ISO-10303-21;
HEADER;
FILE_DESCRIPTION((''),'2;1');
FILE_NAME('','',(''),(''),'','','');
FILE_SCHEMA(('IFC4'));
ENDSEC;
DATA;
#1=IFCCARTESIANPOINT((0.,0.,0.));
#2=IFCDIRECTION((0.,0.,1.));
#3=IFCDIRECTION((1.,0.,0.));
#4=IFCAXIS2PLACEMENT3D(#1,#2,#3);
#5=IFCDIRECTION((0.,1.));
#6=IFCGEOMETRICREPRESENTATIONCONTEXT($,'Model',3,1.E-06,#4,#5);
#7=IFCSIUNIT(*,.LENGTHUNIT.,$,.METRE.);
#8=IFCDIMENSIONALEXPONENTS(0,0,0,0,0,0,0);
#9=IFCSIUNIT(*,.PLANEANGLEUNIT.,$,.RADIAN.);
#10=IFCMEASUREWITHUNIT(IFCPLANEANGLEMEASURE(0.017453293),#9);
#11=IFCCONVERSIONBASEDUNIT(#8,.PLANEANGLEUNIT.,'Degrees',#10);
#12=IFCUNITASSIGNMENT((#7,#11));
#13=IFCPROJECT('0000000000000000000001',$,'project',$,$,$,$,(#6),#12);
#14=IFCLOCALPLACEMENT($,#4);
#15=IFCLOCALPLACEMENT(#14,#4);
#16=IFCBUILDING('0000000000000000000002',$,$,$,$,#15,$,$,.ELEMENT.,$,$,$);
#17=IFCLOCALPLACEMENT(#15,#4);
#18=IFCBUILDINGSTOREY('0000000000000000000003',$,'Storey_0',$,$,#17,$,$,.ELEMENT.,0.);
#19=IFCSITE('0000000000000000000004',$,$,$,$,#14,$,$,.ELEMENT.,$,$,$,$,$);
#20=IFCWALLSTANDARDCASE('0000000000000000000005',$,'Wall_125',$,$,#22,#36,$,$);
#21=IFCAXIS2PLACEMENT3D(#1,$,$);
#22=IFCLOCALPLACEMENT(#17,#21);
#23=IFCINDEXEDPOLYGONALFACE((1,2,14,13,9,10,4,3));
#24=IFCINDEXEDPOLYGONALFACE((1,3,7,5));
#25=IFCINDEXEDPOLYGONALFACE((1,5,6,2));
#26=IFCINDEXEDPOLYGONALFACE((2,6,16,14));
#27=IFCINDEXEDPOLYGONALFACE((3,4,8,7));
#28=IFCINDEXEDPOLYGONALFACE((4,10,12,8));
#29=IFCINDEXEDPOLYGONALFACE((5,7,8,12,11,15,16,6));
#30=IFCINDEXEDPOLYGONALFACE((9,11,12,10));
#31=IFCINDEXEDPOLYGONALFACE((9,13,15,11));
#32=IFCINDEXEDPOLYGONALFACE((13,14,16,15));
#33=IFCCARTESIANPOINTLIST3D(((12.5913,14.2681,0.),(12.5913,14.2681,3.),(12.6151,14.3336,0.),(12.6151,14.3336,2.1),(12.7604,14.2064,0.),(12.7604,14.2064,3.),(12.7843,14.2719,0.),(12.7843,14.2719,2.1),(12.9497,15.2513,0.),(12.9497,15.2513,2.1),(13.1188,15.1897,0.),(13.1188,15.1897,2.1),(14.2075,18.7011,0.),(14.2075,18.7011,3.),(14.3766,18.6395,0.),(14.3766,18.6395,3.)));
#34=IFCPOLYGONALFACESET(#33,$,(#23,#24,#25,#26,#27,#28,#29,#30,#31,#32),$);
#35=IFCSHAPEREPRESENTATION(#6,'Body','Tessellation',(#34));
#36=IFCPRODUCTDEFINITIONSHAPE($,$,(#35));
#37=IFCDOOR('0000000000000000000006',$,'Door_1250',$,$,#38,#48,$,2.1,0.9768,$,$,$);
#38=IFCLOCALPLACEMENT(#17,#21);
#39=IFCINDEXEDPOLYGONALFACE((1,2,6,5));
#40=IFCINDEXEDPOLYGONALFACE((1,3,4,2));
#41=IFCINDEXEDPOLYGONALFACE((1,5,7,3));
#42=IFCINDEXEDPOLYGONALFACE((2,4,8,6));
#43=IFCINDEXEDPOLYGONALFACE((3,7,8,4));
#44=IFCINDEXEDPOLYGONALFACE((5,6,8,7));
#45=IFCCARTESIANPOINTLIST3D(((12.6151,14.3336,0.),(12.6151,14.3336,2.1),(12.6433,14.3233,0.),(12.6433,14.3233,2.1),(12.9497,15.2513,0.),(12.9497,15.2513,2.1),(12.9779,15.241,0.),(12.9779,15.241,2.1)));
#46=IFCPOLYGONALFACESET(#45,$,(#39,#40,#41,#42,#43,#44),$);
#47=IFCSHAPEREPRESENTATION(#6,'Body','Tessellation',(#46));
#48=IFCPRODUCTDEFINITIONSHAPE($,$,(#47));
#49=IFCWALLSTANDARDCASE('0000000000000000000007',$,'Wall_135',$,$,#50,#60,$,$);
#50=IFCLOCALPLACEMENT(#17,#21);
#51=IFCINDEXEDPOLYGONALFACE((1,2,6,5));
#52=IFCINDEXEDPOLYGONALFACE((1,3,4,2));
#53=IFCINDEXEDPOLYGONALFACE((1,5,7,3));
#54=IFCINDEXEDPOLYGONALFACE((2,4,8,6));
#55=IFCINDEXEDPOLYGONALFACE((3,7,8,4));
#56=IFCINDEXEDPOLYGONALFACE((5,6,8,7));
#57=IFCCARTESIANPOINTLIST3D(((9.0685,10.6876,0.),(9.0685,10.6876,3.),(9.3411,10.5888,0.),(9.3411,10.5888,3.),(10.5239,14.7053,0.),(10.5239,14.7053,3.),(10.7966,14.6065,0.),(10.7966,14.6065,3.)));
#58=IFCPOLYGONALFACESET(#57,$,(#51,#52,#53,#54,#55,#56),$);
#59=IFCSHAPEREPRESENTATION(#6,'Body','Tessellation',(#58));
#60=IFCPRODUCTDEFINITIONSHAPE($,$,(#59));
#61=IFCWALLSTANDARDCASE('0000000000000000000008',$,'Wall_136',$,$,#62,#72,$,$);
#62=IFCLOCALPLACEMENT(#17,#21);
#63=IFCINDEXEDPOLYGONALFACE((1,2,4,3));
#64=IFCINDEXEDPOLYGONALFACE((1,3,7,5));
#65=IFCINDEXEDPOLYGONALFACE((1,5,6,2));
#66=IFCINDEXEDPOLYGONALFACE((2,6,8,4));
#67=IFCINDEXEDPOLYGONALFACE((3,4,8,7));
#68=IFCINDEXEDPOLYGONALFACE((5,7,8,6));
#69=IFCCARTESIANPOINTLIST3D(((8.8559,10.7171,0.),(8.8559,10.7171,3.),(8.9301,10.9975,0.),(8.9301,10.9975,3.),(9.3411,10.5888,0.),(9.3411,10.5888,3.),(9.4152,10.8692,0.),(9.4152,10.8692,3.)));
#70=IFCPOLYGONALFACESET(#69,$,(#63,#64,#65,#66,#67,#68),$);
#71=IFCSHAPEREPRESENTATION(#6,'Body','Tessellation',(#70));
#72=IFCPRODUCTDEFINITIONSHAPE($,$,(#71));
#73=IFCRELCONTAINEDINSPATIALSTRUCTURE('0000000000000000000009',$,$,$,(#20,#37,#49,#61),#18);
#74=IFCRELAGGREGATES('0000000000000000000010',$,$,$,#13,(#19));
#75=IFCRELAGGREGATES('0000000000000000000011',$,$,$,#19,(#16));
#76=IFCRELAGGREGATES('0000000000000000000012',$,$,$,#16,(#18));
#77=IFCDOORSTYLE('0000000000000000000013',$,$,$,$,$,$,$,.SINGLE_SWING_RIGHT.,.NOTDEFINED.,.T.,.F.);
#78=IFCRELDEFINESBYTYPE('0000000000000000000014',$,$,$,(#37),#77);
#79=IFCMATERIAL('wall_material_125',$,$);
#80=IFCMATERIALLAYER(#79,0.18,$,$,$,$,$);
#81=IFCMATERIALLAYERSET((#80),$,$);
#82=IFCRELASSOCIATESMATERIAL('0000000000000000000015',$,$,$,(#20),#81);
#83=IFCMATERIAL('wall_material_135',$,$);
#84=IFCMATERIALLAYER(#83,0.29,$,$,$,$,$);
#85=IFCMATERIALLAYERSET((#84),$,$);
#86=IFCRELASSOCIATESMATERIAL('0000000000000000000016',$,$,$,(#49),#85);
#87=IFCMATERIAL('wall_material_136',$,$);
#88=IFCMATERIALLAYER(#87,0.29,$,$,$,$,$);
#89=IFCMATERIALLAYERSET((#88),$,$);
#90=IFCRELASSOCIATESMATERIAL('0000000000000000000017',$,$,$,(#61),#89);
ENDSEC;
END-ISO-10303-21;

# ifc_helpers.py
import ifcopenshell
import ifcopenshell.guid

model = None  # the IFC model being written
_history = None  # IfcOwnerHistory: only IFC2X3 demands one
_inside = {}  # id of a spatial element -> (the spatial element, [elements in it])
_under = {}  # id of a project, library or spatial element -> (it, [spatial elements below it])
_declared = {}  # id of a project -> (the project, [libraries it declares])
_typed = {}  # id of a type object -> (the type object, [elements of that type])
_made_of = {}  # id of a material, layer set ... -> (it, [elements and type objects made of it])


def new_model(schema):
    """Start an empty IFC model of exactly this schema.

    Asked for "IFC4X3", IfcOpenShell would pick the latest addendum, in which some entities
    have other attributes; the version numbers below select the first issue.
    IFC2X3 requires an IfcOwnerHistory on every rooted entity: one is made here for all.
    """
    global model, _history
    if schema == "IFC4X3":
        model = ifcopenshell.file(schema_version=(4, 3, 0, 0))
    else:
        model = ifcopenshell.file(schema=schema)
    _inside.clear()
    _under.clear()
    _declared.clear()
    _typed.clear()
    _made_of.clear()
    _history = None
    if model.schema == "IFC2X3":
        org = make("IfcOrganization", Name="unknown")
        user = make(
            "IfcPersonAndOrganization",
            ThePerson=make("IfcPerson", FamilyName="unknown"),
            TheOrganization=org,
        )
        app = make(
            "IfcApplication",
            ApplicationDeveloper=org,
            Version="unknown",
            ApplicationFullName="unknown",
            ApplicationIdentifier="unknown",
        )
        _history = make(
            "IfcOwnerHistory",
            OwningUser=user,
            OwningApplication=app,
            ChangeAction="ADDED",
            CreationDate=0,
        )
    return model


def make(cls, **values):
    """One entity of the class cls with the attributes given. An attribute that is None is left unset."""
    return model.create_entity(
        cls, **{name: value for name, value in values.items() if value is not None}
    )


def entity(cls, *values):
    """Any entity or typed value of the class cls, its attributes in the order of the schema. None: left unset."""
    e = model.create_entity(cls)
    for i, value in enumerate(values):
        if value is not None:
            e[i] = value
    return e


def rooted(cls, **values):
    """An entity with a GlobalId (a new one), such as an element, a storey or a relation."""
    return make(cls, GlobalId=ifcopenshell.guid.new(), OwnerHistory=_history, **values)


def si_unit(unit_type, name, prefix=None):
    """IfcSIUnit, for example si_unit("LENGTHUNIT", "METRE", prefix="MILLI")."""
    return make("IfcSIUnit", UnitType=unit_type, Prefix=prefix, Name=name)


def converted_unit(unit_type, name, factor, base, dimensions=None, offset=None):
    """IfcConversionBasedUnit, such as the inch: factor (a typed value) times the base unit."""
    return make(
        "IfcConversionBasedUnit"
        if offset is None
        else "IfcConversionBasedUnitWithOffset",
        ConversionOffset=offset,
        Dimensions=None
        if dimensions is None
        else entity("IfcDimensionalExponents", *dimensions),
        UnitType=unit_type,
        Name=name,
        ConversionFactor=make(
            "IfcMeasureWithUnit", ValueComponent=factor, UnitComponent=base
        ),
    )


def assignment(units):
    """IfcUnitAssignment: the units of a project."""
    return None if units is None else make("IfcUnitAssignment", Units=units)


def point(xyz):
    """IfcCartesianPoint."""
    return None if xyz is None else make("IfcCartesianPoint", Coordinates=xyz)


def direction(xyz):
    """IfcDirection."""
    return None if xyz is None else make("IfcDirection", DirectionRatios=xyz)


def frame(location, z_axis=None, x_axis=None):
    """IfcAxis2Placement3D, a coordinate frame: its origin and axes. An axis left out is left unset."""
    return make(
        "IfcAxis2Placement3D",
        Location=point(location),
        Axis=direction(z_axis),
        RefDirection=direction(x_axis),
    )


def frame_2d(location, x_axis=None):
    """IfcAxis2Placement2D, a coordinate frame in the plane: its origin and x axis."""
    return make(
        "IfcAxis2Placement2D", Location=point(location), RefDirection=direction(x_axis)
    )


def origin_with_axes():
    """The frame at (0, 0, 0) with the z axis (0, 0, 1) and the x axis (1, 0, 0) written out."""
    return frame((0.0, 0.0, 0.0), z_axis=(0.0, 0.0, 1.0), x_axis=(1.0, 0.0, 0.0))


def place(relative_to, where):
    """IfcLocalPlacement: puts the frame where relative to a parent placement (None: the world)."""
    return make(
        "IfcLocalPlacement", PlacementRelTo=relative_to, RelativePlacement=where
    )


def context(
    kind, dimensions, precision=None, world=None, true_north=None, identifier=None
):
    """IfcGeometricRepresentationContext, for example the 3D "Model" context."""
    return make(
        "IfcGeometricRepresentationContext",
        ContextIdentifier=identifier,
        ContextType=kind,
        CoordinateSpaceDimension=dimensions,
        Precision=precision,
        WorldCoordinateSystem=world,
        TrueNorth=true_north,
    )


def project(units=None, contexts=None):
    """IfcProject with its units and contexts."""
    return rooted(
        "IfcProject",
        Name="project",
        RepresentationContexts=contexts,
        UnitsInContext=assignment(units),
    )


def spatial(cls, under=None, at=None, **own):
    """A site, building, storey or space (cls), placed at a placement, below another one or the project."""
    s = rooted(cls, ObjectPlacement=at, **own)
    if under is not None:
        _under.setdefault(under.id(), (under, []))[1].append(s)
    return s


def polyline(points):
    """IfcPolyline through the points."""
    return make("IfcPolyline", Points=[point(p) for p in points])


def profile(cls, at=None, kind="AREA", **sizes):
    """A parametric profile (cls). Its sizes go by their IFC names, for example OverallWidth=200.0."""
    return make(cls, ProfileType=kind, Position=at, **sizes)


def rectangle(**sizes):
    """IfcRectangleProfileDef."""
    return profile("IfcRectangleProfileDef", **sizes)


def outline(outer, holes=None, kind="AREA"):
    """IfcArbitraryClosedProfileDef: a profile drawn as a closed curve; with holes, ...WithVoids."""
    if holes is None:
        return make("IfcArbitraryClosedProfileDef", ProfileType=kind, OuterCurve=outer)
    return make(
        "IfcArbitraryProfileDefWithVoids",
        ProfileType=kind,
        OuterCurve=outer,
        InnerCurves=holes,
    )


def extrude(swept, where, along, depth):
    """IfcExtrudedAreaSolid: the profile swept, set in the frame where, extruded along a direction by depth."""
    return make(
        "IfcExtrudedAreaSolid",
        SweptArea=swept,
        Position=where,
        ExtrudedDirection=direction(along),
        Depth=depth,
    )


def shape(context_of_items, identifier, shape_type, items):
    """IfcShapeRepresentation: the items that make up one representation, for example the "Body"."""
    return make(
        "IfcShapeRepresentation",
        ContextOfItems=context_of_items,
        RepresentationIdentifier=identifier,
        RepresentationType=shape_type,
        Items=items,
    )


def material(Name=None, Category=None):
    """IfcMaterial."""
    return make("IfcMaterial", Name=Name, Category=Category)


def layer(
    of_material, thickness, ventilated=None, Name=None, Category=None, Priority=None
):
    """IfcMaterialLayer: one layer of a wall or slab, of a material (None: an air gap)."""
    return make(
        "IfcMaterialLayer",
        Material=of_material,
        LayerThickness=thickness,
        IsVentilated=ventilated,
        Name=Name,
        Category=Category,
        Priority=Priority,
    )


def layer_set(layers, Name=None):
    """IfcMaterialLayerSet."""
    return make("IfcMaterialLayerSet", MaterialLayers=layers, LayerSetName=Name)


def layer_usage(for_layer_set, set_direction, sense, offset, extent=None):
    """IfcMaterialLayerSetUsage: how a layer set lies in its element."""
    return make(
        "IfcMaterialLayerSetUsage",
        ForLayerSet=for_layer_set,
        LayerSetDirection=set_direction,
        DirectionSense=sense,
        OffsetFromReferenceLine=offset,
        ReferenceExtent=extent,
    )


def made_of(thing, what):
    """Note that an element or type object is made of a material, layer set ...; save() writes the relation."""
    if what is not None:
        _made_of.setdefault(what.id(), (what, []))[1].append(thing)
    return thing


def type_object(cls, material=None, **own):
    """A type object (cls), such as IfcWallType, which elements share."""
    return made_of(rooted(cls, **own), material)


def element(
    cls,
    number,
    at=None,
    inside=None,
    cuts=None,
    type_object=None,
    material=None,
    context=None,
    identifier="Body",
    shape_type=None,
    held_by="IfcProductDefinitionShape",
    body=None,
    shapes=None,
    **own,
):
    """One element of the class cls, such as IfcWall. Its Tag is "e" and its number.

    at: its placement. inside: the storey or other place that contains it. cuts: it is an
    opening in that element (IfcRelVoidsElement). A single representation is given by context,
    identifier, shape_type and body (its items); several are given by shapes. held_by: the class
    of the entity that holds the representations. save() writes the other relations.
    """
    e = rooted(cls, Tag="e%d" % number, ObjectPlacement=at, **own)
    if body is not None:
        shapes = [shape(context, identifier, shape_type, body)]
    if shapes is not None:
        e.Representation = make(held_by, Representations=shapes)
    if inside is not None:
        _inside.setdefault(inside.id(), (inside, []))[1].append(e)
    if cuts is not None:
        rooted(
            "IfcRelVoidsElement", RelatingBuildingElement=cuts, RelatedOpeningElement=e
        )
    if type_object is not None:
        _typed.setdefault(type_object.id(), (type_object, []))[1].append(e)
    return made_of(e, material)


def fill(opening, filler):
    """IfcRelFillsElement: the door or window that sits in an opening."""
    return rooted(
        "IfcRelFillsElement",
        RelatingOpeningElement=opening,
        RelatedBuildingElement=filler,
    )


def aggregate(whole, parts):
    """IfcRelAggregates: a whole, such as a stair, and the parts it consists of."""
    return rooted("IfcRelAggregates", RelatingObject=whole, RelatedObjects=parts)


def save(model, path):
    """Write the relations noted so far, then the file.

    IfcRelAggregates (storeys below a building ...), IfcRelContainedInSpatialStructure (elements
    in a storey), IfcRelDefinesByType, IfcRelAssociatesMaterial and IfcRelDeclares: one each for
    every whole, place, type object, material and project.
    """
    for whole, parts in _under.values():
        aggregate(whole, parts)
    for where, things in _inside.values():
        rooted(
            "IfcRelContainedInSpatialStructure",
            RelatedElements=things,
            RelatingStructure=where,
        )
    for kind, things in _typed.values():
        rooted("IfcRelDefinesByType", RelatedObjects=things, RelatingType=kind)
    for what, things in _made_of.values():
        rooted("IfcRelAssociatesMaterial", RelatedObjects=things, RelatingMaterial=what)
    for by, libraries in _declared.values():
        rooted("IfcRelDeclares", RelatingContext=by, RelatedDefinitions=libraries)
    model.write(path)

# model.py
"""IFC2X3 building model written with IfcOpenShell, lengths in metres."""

from ifc_helpers import new_model, entity, si_unit, converted_unit, direction, frame, frame_2d, origin_with_axes, place, context, project, spatial, polyline, rectangle, outline, extrude, material, layer, layer_set, layer_usage, type_object, element, fill, save


model = new_model("IFC2X3")

# Units and contexts
model_context = context("Model", 3, precision=1e-06, world=origin_with_axes(), true_north=direction((0.0, 1.0)))
ifc_project = project(units=[si_unit("LENGTHUNIT", "METRE"), converted_unit("PLANEANGLEUNIT", "Degrees", entity("IfcPlaneAngleMeasure", 0.017453293), si_unit("PLANEANGLEUNIT", "RADIAN"), dimensions=[0, 0, 0, 0, 0, 0, 0])], contexts=[model_context])

# Site, building, storey
site_placement = place(None, origin_with_axes())
site = spatial("IfcSite", under=ifc_project, at=site_placement, CompositionType="ELEMENT")
building_placement = place(site_placement, origin_with_axes())
building = spatial("IfcBuilding", under=site, at=building_placement, CompositionType="ELEMENT")
storey_placement = place(building_placement, origin_with_axes())
storey = spatial("IfcBuildingStorey", under=building, at=storey_placement, Name="Storey_0", CompositionType="ELEMENT", Elevation=0.0)

# Wall, opening, door
ifc_material_1 = material(Name="wall_material_125")
ifc_layer_1 = layer(ifc_material_1, 0.18)
ifc_layer_set_1 = layer_set([ifc_layer_1])
ifc_layer_usage_1 = layer_usage(ifc_layer_set_1, "AXIS2", "POSITIVE", 0.0)
wall_1_placement = place(storey_placement, frame((12.7604, 14.2064, 0.0), z_axis=(0.0, 0.0, 1.0), x_axis=(0.342529, 0.939507, 0.0)))
wall_1 = element("IfcWallStandardCase", 1, at=wall_1_placement, inside=storey, material=ifc_layer_usage_1, Name="Wall_125", context=model_context, shape_type="SweptSolid", body=[
    extrude(outline(polyline([(0.0, 0.18), (4.7185, 0.18), (4.7185, 0.0), (0.0, 0.0), (0.0, 0.18)])), origin_with_axes(), (0.0, 0.0, 1.0), 3.0),
])
opening_1_placement = place(wall_1_placement, frame((0.0697, 0.18, 0.0), z_axis=(0.0, 0.0, 1.0), x_axis=(1.0, 0.0, 0.0)))
opening_1 = element("IfcOpeningElement", 2, at=opening_1_placement, cuts=wall_1, context=model_context, shape_type="SweptSolid", body=[
    extrude(rectangle(XDim=0.9768, YDim=2.1, at=frame_2d((1.05, -0.4884), x_axis=(0.0, 1.0))), frame((0.0, 0.01, 0.0), z_axis=(0.0, -1.0, 0.0), x_axis=(0.0, 0.0, 1.0)), (0.0, 0.0, 1.0), 0.2),
])
door_style_1 = type_object("IfcDoorStyle", ConstructionType="NOTDEFINED", OperationType="SINGLE_SWING_RIGHT", ParameterTakesPrecedence=True, Sizeable=False)
door_1_placement = place(storey_placement, origin_with_axes())
door_1 = element("IfcDoor", 3, at=door_1_placement, inside=storey, type_object=door_style_1, Name="Door_1250", OverallHeight=2.1, OverallWidth=0.9768, context=model_context, shape_type="SweptSolid", body=[
    extrude(outline(polyline([(12.6151, 14.3336), (12.9497, 15.2513), (12.9779, 15.241), (12.6433, 14.3233), (12.6151, 14.3336)])), origin_with_axes(), (0.0, 0.0, 1.0), 2.1),
])
fill(opening_1, door_1)

# Walls
ifc_material_2 = material(Name="wall_material_135")
ifc_layer_2 = layer(ifc_material_2, 0.29)
ifc_layer_set_2 = layer_set([ifc_layer_2])
ifc_layer_usage_2 = layer_usage(ifc_layer_set_2, "AXIS2", "POSITIVE", 0.0)
wall_2_placement = place(storey_placement, frame((10.5239, 14.7053, 0.0), z_axis=(0.0, 0.0, 1.0), x_axis=(-0.340599, -0.940209, 0.0)))
element("IfcWallStandardCase", 4, at=wall_2_placement, inside=storey, material=ifc_layer_usage_2, Name="Wall_135", context=model_context, shape_type="SweptSolid", body=[
    extrude(outline(polyline([(0.0, 0.29), (4.2732, 0.29), (4.2732, 0.0), (0.0, 0.0), (0.0, 0.29)])), origin_with_axes(), (0.0, 0.0, 1.0), 3.0),
])
ifc_material_3 = material(Name="wall_material_136")
ifc_layer_3 = layer(ifc_material_3, 0.29)
ifc_layer_set_3 = layer_set([ifc_layer_3])
ifc_layer_usage_3 = layer_usage(ifc_layer_set_3, "AXIS2", "POSITIVE", 0.0)
wall_3_placement = place(storey_placement, frame((9.4152, 10.8692, 0.0), z_axis=(0.0, 0.0, 1.0), x_axis=(-0.96678, 0.255609, 0.0)))
element("IfcWallStandardCase", 5, at=wall_3_placement, inside=storey, material=ifc_layer_usage_3, Name="Wall_136", context=model_context, shape_type="SweptSolid", body=[
    extrude(outline(polyline([(0.0, 0.29), (0.5019, 0.29), (0.5019, 0.0), (0.0, 0.0), (0.0, 0.29)])), origin_with_axes(), (0.0, 0.0, 1.0), 3.0),
])

save(model, "model.ifc")
